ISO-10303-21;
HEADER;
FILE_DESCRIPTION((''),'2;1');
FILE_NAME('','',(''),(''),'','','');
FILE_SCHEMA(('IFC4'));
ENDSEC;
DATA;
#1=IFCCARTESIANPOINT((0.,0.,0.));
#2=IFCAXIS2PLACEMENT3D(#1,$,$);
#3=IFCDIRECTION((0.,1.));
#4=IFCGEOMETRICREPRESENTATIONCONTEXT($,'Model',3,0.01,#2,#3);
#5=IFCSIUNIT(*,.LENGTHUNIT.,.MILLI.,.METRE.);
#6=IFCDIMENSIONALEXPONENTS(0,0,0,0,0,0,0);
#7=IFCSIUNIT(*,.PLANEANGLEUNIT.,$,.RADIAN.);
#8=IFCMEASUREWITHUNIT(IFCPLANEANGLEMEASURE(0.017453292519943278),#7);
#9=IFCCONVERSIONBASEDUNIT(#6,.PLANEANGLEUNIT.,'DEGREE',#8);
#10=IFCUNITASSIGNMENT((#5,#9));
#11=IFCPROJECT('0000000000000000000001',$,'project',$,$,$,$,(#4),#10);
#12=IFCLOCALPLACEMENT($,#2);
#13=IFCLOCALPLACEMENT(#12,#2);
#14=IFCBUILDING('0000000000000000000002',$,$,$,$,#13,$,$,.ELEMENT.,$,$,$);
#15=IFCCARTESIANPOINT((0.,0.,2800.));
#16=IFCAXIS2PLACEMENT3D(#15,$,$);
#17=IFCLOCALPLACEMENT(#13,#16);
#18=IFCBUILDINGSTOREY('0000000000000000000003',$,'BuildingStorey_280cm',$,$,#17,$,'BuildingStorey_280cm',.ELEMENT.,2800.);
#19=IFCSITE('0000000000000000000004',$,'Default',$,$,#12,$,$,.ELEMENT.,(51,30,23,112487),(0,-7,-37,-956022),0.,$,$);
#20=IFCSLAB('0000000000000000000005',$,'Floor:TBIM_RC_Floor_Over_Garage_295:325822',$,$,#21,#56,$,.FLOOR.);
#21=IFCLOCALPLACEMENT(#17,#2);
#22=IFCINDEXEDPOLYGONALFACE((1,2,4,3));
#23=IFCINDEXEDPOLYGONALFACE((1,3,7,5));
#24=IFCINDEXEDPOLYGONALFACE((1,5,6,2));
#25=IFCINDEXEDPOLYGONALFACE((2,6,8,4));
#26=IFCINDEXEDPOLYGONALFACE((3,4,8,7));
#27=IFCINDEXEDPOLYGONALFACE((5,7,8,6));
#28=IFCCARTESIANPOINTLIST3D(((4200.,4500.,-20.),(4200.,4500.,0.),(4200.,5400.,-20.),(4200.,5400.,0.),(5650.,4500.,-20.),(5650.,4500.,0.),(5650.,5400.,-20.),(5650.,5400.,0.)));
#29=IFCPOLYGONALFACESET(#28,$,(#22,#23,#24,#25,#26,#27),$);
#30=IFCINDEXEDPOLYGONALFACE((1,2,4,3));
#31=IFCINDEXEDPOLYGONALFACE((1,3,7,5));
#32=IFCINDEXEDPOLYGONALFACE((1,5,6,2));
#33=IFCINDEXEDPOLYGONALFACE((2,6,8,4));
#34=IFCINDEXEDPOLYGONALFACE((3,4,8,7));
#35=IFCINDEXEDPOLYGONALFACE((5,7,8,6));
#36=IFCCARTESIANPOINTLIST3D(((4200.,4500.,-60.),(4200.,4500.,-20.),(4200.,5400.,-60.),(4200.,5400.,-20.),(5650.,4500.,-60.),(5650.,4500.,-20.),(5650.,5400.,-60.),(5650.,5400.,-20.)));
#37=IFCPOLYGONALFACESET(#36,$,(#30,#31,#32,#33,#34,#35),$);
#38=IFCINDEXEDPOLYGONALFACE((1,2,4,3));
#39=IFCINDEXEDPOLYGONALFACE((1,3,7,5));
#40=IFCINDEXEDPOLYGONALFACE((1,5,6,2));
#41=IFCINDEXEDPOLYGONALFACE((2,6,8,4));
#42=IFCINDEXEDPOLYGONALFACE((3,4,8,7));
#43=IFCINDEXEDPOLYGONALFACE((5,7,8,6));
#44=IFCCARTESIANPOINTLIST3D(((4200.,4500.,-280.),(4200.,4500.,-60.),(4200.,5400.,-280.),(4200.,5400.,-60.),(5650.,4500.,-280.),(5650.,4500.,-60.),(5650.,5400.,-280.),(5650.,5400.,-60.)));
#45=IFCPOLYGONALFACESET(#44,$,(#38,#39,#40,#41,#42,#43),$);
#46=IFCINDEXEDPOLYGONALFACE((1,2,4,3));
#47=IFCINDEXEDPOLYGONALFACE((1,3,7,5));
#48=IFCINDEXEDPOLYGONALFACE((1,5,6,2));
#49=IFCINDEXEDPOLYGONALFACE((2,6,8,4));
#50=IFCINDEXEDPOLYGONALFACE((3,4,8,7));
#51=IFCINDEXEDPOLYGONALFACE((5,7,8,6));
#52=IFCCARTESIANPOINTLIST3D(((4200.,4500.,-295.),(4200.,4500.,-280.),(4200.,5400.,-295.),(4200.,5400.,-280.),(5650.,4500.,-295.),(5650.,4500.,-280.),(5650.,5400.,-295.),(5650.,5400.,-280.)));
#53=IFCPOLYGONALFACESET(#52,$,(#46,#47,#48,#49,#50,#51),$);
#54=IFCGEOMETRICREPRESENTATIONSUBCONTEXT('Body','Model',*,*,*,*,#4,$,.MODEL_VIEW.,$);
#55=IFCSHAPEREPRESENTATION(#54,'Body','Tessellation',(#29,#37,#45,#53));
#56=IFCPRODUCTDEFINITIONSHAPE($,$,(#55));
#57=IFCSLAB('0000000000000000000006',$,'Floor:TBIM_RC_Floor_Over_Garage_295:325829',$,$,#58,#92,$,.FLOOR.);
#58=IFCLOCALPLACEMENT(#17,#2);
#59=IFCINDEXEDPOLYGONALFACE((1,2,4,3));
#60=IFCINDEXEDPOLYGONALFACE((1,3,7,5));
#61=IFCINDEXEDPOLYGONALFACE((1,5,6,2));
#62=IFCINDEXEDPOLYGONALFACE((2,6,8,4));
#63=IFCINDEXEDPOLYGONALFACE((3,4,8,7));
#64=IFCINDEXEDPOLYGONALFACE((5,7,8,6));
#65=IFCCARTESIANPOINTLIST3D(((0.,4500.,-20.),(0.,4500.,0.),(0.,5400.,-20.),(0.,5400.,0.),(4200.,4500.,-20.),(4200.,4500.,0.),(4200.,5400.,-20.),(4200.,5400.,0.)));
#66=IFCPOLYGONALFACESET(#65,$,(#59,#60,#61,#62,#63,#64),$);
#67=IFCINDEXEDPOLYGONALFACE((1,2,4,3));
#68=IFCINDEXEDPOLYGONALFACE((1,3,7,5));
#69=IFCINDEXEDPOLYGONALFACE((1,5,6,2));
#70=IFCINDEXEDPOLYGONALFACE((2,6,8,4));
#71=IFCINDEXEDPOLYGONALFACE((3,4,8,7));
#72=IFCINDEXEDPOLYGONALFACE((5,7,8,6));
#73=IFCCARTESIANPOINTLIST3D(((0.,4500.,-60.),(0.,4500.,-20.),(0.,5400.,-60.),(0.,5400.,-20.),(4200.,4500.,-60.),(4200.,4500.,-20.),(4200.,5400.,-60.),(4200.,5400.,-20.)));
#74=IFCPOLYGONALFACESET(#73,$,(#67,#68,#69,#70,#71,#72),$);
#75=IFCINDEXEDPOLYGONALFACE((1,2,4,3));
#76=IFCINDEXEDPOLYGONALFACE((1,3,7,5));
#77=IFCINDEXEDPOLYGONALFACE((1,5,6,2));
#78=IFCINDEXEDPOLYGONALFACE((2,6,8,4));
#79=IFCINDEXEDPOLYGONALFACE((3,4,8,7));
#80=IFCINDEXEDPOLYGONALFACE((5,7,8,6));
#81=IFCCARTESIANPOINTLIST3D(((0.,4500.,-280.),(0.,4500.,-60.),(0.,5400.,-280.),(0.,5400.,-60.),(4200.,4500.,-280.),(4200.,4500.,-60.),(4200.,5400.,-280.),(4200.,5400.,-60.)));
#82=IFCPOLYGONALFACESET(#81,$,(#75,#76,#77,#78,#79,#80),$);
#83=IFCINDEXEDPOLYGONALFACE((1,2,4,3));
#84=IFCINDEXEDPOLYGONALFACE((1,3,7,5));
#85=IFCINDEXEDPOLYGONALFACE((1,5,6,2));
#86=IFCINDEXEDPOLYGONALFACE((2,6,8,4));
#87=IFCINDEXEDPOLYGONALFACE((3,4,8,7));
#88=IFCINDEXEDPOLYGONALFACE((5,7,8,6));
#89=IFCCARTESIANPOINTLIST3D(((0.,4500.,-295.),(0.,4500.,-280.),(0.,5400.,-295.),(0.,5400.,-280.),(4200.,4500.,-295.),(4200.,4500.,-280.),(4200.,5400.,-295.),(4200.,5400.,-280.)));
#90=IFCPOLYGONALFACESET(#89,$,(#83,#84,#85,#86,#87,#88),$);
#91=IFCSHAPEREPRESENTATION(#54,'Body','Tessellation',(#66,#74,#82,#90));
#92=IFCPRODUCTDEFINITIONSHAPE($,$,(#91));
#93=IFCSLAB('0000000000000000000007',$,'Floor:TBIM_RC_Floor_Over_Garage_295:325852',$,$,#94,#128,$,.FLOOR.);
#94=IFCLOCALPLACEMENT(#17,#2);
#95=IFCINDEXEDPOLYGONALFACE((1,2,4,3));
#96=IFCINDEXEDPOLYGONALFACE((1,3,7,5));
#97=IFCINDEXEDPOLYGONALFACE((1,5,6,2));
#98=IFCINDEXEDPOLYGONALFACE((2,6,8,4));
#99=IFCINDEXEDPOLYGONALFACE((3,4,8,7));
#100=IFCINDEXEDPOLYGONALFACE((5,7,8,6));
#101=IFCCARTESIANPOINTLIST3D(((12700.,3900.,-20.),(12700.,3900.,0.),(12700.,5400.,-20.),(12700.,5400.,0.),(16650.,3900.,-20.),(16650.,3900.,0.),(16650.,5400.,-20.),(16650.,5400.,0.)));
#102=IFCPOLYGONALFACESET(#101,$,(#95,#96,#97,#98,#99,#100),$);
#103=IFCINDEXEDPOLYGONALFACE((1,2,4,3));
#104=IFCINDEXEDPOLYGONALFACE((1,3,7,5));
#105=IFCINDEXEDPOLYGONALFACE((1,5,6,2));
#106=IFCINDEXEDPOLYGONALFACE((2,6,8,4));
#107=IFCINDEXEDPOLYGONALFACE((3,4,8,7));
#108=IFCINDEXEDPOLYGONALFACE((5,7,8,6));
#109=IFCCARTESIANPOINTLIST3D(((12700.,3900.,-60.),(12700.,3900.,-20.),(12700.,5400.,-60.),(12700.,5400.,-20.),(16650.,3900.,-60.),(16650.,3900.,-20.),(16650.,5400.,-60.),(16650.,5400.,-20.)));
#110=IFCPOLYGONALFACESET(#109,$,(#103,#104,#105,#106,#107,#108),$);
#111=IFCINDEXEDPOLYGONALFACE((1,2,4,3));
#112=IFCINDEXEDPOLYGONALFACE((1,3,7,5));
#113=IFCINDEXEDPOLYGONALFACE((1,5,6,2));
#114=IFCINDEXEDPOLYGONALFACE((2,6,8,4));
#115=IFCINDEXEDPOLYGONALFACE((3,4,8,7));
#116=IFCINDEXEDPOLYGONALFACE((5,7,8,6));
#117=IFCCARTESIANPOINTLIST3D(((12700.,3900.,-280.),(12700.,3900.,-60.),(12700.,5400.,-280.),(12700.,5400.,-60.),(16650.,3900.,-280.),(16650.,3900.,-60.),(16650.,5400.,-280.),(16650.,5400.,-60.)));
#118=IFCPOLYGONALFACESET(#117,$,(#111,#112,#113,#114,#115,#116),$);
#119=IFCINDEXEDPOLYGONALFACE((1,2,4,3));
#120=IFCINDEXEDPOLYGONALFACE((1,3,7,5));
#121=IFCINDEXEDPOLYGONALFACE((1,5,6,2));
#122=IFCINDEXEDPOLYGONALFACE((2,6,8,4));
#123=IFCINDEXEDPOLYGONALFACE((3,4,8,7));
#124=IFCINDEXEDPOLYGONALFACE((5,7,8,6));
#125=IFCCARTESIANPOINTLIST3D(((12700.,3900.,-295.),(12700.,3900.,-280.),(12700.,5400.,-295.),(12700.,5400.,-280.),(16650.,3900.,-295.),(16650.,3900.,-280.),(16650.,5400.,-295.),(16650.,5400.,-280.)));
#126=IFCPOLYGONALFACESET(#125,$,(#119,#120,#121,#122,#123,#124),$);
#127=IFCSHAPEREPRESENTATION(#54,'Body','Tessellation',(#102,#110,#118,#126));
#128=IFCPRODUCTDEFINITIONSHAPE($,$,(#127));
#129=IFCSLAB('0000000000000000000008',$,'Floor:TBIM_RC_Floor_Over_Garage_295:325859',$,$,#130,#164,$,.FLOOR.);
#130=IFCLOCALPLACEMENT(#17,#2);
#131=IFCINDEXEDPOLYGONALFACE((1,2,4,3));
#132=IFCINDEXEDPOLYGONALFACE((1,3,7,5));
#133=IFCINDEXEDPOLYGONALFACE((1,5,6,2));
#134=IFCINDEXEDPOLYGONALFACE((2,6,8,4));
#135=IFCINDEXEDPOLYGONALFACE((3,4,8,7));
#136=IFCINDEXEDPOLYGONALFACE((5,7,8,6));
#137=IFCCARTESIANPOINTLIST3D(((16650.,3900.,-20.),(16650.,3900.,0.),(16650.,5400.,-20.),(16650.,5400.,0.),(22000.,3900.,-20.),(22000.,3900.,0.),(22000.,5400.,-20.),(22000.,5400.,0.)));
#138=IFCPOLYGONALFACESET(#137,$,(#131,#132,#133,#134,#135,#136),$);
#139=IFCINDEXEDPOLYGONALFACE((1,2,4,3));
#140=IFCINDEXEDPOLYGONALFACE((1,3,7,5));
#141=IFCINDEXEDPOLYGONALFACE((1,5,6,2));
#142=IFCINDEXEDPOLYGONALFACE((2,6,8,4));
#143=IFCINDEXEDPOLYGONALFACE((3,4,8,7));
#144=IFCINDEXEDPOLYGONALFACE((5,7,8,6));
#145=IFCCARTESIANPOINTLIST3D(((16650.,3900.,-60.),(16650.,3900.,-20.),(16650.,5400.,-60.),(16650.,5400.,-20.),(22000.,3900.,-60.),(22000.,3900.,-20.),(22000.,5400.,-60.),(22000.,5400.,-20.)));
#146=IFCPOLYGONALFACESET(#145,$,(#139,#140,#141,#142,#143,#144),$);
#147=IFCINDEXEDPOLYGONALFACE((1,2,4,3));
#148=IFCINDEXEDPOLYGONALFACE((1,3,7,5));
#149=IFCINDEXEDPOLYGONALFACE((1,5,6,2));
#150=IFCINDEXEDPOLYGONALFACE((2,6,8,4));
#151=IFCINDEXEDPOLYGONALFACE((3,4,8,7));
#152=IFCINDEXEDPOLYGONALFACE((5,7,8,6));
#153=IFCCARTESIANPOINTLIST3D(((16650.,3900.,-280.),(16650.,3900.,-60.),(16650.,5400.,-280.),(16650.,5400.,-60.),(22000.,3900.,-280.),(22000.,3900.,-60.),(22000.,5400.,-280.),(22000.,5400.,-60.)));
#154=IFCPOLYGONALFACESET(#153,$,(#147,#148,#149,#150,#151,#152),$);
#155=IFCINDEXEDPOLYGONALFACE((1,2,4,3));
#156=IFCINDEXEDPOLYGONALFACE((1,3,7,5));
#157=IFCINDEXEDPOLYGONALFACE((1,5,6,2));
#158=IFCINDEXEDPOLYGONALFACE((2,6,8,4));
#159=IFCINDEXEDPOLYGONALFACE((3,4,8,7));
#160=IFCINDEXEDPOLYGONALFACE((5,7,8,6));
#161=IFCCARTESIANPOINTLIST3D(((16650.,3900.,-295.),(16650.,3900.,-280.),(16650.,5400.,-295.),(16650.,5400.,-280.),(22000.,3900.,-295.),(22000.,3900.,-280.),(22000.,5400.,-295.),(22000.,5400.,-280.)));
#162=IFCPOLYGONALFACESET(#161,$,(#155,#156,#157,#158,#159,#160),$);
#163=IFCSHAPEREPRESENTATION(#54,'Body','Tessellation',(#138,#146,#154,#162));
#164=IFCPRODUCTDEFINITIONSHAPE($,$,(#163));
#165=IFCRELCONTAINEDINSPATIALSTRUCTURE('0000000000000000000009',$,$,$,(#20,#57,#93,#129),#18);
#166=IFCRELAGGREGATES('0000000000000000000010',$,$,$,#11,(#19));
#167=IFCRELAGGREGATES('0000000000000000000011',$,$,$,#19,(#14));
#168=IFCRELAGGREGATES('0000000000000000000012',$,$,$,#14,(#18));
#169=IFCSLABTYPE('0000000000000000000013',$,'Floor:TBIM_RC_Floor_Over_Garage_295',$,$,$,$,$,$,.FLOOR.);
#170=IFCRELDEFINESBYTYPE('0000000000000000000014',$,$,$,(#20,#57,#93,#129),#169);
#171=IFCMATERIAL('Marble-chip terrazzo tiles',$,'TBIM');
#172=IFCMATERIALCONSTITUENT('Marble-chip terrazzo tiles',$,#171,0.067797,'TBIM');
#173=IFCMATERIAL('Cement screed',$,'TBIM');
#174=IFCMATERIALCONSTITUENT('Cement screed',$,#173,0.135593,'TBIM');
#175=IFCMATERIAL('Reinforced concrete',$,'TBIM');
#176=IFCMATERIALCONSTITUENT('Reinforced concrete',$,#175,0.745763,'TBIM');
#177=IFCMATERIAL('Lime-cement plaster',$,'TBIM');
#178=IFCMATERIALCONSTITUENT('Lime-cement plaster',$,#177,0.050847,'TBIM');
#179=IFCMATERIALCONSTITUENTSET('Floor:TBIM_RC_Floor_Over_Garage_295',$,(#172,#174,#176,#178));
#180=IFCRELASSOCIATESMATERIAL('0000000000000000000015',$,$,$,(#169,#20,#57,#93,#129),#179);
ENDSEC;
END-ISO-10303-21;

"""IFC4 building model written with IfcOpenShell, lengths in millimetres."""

from ifc_helpers import new_model, entity, si_unit, converted_unit, direction, frame, origin, place, context, subcontext, project, spatial, indexed_curve, outline, extrude, material, constituent, constituent_set, type_object, element, save


model = new_model("IFC4")

# Units and contexts
model_context = context("Model", 3, precision=0.01, world=origin(), true_north=direction((0.0, 1.0)))
body_context = subcontext(model_context, "Body", "Model", "MODEL_VIEW")
ifc_project = project(units=[si_unit("LENGTHUNIT", "METRE", prefix="MILLI"), converted_unit("PLANEANGLEUNIT", "DEGREE", entity("IfcPlaneAngleMeasure", 0.017453292519943278), si_unit("PLANEANGLEUNIT", "RADIAN"), dimensions=[0, 0, 0, 0, 0, 0, 0])], contexts=[model_context])

# Site, building, storey
site_placement = place(None, origin())
site = spatial("IfcSite", under=ifc_project, at=site_placement, Name="Default", CompositionType="ELEMENT", RefLatitude=(51, 30, 23, 112487), RefLongitude=(0, -7, -37, -956022), RefElevation=0.0)
building_placement = place(site_placement, origin())
building = spatial("IfcBuilding", under=site, at=building_placement, CompositionType="ELEMENT")
storey_placement = place(building_placement, frame((0.0, 0.0, 2800.0)))
storey = spatial("IfcBuildingStorey", under=building, at=storey_placement, Name="BuildingStorey_280cm", LongName="BuildingStorey_280cm", CompositionType="ELEMENT", Elevation=2800.0)

# Slabs
ifc_material_1 = material(Name="Marble-chip terrazzo tiles", Category="TBIM")
ifc_constituent_1 = constituent(ifc_material_1, Name="Marble-chip terrazzo tiles", Category="TBIM", fraction=0.067797)
ifc_material_2 = material(Name="Cement screed", Category="TBIM")
ifc_constituent_2 = constituent(ifc_material_2, Name="Cement screed", Category="TBIM", fraction=0.135593)
ifc_material_3 = material(Name="Reinforced concrete", Category="TBIM")
ifc_constituent_3 = constituent(ifc_material_3, Name="Reinforced concrete", Category="TBIM", fraction=0.745763)
ifc_material_4 = material(Name="Lime-cement plaster", Category="TBIM")
ifc_constituent_4 = constituent(ifc_material_4, Name="Lime-cement plaster", Category="TBIM", fraction=0.050847)
ifc_constituent_set_1 = constituent_set(constituents=[ifc_constituent_1, ifc_constituent_2, ifc_constituent_3, ifc_constituent_4], Name="Floor:TBIM_RC_Floor_Over_Garage_295")
slab_type_1 = type_object("IfcSlabType", Name="Floor:TBIM_RC_Floor_Over_Garage_295", PredefinedType="FLOOR", material=ifc_constituent_set_1)
slab_1_placement = place(storey_placement, origin())
element("IfcSlab", 1, at=slab_1_placement, inside=storey, type_object=slab_type_1, material=ifc_constituent_set_1, Name="Floor:TBIM_RC_Floor_Over_Garage_295:325822", PredefinedType="FLOOR", context=body_context, shape_type="SweptSolid", body=[
    extrude(outline(indexed_curve([(-725.0, -450.0), (725.0, -450.0), (725.0, 450.0), (-725.0, 450.0), (-725.0, -450.0)], self_intersect=False)), frame((4925.0, 4950.0, -20.0), z_axis=(0.0, 0.0, 1.0), x_axis=(-1.0, 0.0, 0.0)), (0.0, 0.0, 1.0), 20.0),
    extrude(outline(indexed_curve([(-725.0, -450.0), (725.0, -450.0), (725.0, 450.0), (-725.0, 450.0), (-725.0, -450.0)], self_intersect=False)), frame((4925.0, 4950.0, -60.0), z_axis=(0.0, 0.0, 1.0), x_axis=(-1.0, 0.0, 0.0)), (0.0, 0.0, 1.0), 40.0),
    extrude(outline(indexed_curve([(-725.0, -450.0), (725.0, -450.0), (725.0, 450.0), (-725.0, 450.0), (-725.0, -450.0)], self_intersect=False)), frame((4925.0, 4950.0, -280.0), z_axis=(0.0, 0.0, 1.0), x_axis=(-1.0, 0.0, 0.0)), (0.0, 0.0, 1.0), 220.0),
    extrude(outline(indexed_curve([(-725.0, -450.0), (725.0, -450.0), (725.0, 450.0), (-725.0, 450.0), (-725.0, -450.0)], self_intersect=False)), frame((4925.0, 4950.0, -295.0), z_axis=(0.0, 0.0, 1.0), x_axis=(-1.0, 0.0, 0.0)), (0.0, 0.0, 1.0), 15.0),
])
slab_2_placement = place(storey_placement, origin())
element("IfcSlab", 2, at=slab_2_placement, inside=storey, type_object=slab_type_1, material=ifc_constituent_set_1, Name="Floor:TBIM_RC_Floor_Over_Garage_295:325829", PredefinedType="FLOOR", context=body_context, shape_type="SweptSolid", body=[
    extrude(outline(indexed_curve([(-2100.0, -450.0), (2100.0, -450.0), (2100.0, 450.0), (-2100.0, 450.0), (-2100.0, -450.0)], self_intersect=False)), frame((2100.0, 4950.0, -20.0), z_axis=(0.0, 0.0, 1.0), x_axis=(-1.0, 0.0, 0.0)), (0.0, 0.0, 1.0), 20.0),
    extrude(outline(indexed_curve([(-2100.0, -450.0), (2100.0, -450.0), (2100.0, 450.0), (-2100.0, 450.0), (-2100.0, -450.0)], self_intersect=False)), frame((2100.0, 4950.0, -60.0), z_axis=(0.0, 0.0, 1.0), x_axis=(-1.0, 0.0, 0.0)), (0.0, 0.0, 1.0), 40.0),
    extrude(outline(indexed_curve([(-2100.0, -450.0), (2100.0, -450.0), (2100.0, 450.0), (-2100.0, 450.0), (-2100.0, -450.0)], self_intersect=False)), frame((2100.0, 4950.0, -280.0), z_axis=(0.0, 0.0, 1.0), x_axis=(-1.0, 0.0, 0.0)), (0.0, 0.0, 1.0), 220.0),
    extrude(outline(indexed_curve([(-2100.0, -450.0), (2100.0, -450.0), (2100.0, 450.0), (-2100.0, 450.0), (-2100.0, -450.0)], self_intersect=False)), frame((2100.0, 4950.0, -295.0), z_axis=(0.0, 0.0, 1.0), x_axis=(-1.0, 0.0, 0.0)), (0.0, 0.0, 1.0), 15.0),
])
slab_3_placement = place(storey_placement, origin())
element("IfcSlab", 3, at=slab_3_placement, inside=storey, type_object=slab_type_1, material=ifc_constituent_set_1, Name="Floor:TBIM_RC_Floor_Over_Garage_295:325852", PredefinedType="FLOOR", context=body_context, shape_type="SweptSolid", body=[
    extrude(outline(indexed_curve([(-1975.0, -750.0), (1975.0, -750.0), (1975.0, 750.0), (-1975.0, 750.0), (-1975.0, -750.0)], self_intersect=False)), frame((14675.0, 4650.0, -20.0), z_axis=(0.0, 0.0, 1.0), x_axis=(-1.0, 0.0, 0.0)), (0.0, 0.0, 1.0), 20.0),
    extrude(outline(indexed_curve([(-1975.0, -750.0), (1975.0, -750.0), (1975.0, 750.0), (-1975.0, 750.0), (-1975.0, -750.0)], self_intersect=False)), frame((14675.0, 4650.0, -60.0), z_axis=(0.0, 0.0, 1.0), x_axis=(-1.0, 0.0, 0.0)), (0.0, 0.0, 1.0), 40.0),
    extrude(outline(indexed_curve([(-1975.0, -750.0), (1975.0, -750.0), (1975.0, 750.0), (-1975.0, 750.0), (-1975.0, -750.0)], self_intersect=False)), frame((14675.0, 4650.0, -280.0), z_axis=(0.0, 0.0, 1.0), x_axis=(-1.0, 0.0, 0.0)), (0.0, 0.0, 1.0), 220.0),
    extrude(outline(indexed_curve([(-1975.0, -750.0), (1975.0, -750.0), (1975.0, 750.0), (-1975.0, 750.0), (-1975.0, -750.0)], self_intersect=False)), frame((14675.0, 4650.0, -295.0), z_axis=(0.0, 0.0, 1.0), x_axis=(-1.0, 0.0, 0.0)), (0.0, 0.0, 1.0), 15.0),
])
slab_4_placement = place(storey_placement, origin())
element("IfcSlab", 4, at=slab_4_placement, inside=storey, type_object=slab_type_1, material=ifc_constituent_set_1, Name="Floor:TBIM_RC_Floor_Over_Garage_295:325859", PredefinedType="FLOOR", context=body_context, shape_type="SweptSolid", body=[
    extrude(outline(indexed_curve([(-2675.0, -750.0), (2675.0, -750.0), (2675.0, 750.0), (-2675.0, 750.0), (-2675.0, -750.0)], self_intersect=False)), frame((19325.0, 4650.0, -20.0), z_axis=(0.0, 0.0, 1.0), x_axis=(-1.0, 0.0, 0.0)), (0.0, 0.0, 1.0), 20.0),
    extrude(outline(indexed_curve([(-2675.0, -750.0), (2675.0, -750.0), (2675.0, 750.0), (-2675.0, 750.0), (-2675.0, -750.0)], self_intersect=False)), frame((19325.0, 4650.0, -60.0), z_axis=(0.0, 0.0, 1.0), x_axis=(-1.0, 0.0, 0.0)), (0.0, 0.0, 1.0), 40.0),
    extrude(outline(indexed_curve([(-2675.0, -750.0), (2675.0, -750.0), (2675.0, 750.0), (-2675.0, 750.0), (-2675.0, -750.0)], self_intersect=False)), frame((19325.0, 4650.0, -280.0), z_axis=(0.0, 0.0, 1.0), x_axis=(-1.0, 0.0, 0.0)), (0.0, 0.0, 1.0), 220.0),
    extrude(outline(indexed_curve([(-2675.0, -750.0), (2675.0, -750.0), (2675.0, 750.0), (-2675.0, 750.0), (-2675.0, -750.0)], self_intersect=False)), frame((19325.0, 4650.0, -295.0), z_axis=(0.0, 0.0, 1.0), x_axis=(-1.0, 0.0, 0.0)), (0.0, 0.0, 1.0), 15.0),
])

save(model, "model.ifc")
